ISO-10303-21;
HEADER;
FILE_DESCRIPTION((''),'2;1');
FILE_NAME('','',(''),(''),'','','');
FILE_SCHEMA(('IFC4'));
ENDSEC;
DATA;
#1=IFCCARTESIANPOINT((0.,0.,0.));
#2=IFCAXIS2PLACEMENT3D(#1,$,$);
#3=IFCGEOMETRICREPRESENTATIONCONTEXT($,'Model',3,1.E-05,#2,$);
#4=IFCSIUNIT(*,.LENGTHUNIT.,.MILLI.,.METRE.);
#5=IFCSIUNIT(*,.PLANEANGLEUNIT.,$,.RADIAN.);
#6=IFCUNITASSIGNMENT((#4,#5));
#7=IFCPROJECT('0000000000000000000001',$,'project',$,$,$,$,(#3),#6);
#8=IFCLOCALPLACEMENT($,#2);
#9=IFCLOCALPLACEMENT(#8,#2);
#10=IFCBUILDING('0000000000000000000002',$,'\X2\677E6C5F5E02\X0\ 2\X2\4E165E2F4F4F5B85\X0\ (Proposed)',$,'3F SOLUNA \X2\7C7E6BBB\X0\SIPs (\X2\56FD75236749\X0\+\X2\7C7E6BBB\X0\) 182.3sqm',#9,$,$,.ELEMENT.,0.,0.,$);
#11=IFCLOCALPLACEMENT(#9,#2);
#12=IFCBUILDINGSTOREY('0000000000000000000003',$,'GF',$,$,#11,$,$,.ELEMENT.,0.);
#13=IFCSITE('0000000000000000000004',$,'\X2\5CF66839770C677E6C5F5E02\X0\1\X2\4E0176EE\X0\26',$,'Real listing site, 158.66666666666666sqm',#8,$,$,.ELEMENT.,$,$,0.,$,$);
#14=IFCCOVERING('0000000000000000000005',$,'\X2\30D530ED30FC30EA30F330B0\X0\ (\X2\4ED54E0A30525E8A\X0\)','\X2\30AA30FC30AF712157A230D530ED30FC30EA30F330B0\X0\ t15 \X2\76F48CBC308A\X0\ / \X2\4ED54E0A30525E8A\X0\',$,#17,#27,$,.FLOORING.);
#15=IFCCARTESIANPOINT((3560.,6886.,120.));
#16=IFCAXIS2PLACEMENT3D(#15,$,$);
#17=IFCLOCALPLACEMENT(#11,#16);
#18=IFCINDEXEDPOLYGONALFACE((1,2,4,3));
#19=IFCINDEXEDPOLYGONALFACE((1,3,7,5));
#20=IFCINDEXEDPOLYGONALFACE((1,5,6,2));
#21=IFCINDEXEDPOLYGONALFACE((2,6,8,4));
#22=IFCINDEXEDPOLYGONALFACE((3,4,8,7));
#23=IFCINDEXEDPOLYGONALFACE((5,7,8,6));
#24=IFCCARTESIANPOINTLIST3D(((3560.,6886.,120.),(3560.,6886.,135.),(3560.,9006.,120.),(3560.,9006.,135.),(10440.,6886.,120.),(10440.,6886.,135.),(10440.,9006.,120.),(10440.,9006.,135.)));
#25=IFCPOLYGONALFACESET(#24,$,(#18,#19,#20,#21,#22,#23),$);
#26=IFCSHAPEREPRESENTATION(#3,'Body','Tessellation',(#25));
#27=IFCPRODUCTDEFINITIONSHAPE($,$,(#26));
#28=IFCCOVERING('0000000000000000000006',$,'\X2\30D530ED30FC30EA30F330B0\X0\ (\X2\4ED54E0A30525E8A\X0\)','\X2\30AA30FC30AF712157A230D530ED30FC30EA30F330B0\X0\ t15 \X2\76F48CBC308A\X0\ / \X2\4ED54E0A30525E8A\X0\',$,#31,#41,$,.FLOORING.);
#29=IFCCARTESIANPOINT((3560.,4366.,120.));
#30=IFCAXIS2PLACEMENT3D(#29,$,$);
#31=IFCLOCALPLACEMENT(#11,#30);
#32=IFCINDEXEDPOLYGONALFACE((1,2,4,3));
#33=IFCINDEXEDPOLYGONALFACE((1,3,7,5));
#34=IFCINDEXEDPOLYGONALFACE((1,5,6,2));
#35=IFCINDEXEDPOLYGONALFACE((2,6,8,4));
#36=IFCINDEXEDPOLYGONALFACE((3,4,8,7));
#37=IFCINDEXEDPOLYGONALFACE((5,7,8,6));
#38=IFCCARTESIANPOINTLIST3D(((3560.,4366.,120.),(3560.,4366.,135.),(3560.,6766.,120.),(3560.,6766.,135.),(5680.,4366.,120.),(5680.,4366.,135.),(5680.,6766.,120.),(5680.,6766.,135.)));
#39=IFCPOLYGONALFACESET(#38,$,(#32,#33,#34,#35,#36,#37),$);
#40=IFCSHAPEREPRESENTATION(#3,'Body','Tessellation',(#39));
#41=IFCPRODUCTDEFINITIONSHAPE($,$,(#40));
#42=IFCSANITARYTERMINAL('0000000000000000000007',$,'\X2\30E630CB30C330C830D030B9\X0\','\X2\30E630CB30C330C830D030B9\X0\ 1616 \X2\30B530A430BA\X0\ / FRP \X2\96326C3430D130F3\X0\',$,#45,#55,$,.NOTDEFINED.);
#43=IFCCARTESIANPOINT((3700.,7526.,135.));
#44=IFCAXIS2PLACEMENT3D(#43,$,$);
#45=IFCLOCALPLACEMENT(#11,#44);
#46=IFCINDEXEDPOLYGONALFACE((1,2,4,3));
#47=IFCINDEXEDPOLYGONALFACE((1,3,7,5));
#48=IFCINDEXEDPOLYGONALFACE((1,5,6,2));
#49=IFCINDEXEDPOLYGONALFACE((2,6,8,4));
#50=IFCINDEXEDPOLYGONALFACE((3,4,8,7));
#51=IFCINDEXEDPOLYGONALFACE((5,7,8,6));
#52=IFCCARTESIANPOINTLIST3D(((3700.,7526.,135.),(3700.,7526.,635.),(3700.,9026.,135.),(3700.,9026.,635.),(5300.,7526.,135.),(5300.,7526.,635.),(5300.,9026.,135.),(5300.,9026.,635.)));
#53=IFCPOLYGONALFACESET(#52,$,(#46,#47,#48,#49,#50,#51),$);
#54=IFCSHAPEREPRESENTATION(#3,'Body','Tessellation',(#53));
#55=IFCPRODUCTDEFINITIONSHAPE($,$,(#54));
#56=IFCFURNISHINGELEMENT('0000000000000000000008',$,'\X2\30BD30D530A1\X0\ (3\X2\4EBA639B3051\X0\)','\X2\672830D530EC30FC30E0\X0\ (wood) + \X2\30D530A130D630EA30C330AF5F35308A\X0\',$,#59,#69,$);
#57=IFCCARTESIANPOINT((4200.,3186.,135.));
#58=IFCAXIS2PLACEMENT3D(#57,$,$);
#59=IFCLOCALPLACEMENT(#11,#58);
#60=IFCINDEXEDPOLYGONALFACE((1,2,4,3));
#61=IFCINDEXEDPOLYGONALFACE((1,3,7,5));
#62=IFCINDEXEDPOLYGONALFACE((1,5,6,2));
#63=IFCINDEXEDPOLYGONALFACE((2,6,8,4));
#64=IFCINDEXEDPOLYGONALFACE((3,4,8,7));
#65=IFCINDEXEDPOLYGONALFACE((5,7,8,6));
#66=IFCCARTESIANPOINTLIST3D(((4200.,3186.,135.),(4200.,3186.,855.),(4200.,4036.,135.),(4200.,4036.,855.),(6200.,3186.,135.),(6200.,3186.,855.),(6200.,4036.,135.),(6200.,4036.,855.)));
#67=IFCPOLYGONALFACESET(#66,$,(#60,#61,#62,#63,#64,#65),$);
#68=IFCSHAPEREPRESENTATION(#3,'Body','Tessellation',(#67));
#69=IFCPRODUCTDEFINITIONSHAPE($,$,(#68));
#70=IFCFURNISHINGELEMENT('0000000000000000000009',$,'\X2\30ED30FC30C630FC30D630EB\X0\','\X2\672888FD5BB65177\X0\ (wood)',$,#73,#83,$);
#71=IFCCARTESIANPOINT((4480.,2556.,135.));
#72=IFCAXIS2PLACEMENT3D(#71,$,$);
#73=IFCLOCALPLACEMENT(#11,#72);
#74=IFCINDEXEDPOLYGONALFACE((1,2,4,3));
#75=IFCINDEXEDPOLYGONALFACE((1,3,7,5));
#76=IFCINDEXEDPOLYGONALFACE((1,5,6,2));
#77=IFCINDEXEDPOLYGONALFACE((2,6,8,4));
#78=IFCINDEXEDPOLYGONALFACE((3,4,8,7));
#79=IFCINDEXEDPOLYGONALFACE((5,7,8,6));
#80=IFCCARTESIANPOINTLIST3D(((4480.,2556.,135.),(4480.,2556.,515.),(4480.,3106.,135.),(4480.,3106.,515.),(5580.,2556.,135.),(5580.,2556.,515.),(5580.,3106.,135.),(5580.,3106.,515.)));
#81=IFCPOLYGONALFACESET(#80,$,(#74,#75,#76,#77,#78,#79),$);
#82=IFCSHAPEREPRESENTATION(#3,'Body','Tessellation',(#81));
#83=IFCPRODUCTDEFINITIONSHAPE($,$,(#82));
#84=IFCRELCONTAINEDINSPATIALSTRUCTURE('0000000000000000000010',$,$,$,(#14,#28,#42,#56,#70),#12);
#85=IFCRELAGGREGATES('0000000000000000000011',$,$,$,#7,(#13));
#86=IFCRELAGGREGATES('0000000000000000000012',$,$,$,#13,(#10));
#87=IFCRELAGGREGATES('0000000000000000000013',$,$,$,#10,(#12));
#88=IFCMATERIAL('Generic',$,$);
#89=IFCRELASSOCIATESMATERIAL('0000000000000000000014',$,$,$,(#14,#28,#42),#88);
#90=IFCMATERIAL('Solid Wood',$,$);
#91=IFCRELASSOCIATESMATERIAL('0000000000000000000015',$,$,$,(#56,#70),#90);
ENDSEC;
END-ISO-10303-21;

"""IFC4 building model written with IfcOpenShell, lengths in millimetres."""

from ifc_helpers import new_model, si_unit, frame, frame_2d, origin, place, context, project, spatial, rectangle, extrude, material, element, save


model = new_model("IFC4")

# Units and contexts
model_context = context("Model", 3, precision=1e-05, world=origin())
ifc_project = project(units=[si_unit("LENGTHUNIT", "METRE", prefix="MILLI"), si_unit("PLANEANGLEUNIT", "RADIAN")], contexts=[model_context])

# Site, building, storey
site_placement = place(None, origin())
site = spatial("IfcSite", under=ifc_project, at=site_placement, Name="島根県松江市1丁目26", ObjectType="Real listing site, 158.66666666666666sqm", CompositionType="ELEMENT", RefElevation=0.0)
building_placement = place(site_placement, origin())
building = spatial("IfcBuilding", under=site, at=building_placement, Name="松江市 2世帯住宅 (Proposed)", ObjectType="3F SOLUNA 籾殻SIPs (国産杉+籾殻) 182.3sqm", CompositionType="ELEMENT", ElevationOfRefHeight=0.0, ElevationOfTerrain=0.0)
storey_placement = place(building_placement, origin())
storey = spatial("IfcBuildingStorey", under=building, at=storey_placement, Name="GF", CompositionType="ELEMENT", Elevation=0.0)

# Shared definitions
ifc_material_1 = material(Name="Solid Wood")

# Coverings
ifc_material_2 = material(Name="Generic")
covering_1_placement = place(storey_placement, frame((3560.0, 6886.0, 120.0)))
element("IfcCovering", 1, at=covering_1_placement, inside=storey, material=ifc_material_2, Name="フローリング (仕上げ床)", Description="オーク無垢フローリング t15 直貼り / 仕上げ床", PredefinedType="FLOORING", context=model_context, shape_type="SweptSolid", body=[
    extrude(rectangle(XDim=6880.0, YDim=2120.0, at=frame_2d((3440.0, 1060.0))), frame((3560.0, 6886.0, 120.0)), (0.0, 0.0, 1.0), 15.0),
])
covering_2_placement = place(storey_placement, frame((3560.0, 4366.0, 120.0)))
element("IfcCovering", 2, at=covering_2_placement, inside=storey, material=ifc_material_2, Name="フローリング (仕上げ床)", Description="オーク無垢フローリング t15 直貼り / 仕上げ床", PredefinedType="FLOORING", context=model_context, shape_type="SweptSolid", body=[
    extrude(rectangle(XDim=2120.0, YDim=2400.0, at=frame_2d((1060.0, 1200.0))), frame((3560.0, 4366.0, 120.0)), (0.0, 0.0, 1.0), 15.0),
])

# Sanitary terminal
sanitary_terminal_placement = place(storey_placement, frame((3700.0, 7526.0, 135.0)))
element("IfcSanitaryTerminal", 3, at=sanitary_terminal_placement, inside=storey, material=ifc_material_2, Name="ユニットバス", Description="ユニットバス 1616 サイズ / FRP 防水パン", PredefinedType="NOTDEFINED", context=model_context, shape_type="SweptSolid", body=[
    extrude(rectangle(XDim=1600.0, YDim=1500.0, at=frame_2d((800.0, 750.0))), frame((3700.0, 7526.0, 135.0)), (0.0, 0.0, 1.0), 500.0),
])

# Furnishing elements
furnishing_1_placement = place(storey_placement, frame((4200.0, 3186.0, 135.0)))
element("IfcFurnishingElement", 4, at=furnishing_1_placement, inside=storey, material=ifc_material_1, Name="ソファ (3人掛け)", Description="木フレーム (wood) + ファブリック張り", context=model_context, shape_type="SweptSolid", body=[
    extrude(rectangle(XDim=2000.0, YDim=850.0, at=frame_2d((1000.0, 425.0))), frame((4200.0, 3186.0, 135.0)), (0.0, 0.0, 1.0), 720.0),
])
furnishing_2_placement = place(storey_placement, frame((4480.0, 2556.0, 135.0)))
element("IfcFurnishingElement", 5, at=furnishing_2_placement, inside=storey, material=ifc_material_1, Name="ローテーブル", Description="木製家具 (wood)", context=model_context, shape_type="SweptSolid", body=[
    extrude(rectangle(XDim=1100.0, YDim=550.0, at=frame_2d((550.0, 275.0))), frame((4480.0, 2556.0, 135.0)), (0.0, 0.0, 1.0), 380.0),
])

save(model, "model.ifc")
